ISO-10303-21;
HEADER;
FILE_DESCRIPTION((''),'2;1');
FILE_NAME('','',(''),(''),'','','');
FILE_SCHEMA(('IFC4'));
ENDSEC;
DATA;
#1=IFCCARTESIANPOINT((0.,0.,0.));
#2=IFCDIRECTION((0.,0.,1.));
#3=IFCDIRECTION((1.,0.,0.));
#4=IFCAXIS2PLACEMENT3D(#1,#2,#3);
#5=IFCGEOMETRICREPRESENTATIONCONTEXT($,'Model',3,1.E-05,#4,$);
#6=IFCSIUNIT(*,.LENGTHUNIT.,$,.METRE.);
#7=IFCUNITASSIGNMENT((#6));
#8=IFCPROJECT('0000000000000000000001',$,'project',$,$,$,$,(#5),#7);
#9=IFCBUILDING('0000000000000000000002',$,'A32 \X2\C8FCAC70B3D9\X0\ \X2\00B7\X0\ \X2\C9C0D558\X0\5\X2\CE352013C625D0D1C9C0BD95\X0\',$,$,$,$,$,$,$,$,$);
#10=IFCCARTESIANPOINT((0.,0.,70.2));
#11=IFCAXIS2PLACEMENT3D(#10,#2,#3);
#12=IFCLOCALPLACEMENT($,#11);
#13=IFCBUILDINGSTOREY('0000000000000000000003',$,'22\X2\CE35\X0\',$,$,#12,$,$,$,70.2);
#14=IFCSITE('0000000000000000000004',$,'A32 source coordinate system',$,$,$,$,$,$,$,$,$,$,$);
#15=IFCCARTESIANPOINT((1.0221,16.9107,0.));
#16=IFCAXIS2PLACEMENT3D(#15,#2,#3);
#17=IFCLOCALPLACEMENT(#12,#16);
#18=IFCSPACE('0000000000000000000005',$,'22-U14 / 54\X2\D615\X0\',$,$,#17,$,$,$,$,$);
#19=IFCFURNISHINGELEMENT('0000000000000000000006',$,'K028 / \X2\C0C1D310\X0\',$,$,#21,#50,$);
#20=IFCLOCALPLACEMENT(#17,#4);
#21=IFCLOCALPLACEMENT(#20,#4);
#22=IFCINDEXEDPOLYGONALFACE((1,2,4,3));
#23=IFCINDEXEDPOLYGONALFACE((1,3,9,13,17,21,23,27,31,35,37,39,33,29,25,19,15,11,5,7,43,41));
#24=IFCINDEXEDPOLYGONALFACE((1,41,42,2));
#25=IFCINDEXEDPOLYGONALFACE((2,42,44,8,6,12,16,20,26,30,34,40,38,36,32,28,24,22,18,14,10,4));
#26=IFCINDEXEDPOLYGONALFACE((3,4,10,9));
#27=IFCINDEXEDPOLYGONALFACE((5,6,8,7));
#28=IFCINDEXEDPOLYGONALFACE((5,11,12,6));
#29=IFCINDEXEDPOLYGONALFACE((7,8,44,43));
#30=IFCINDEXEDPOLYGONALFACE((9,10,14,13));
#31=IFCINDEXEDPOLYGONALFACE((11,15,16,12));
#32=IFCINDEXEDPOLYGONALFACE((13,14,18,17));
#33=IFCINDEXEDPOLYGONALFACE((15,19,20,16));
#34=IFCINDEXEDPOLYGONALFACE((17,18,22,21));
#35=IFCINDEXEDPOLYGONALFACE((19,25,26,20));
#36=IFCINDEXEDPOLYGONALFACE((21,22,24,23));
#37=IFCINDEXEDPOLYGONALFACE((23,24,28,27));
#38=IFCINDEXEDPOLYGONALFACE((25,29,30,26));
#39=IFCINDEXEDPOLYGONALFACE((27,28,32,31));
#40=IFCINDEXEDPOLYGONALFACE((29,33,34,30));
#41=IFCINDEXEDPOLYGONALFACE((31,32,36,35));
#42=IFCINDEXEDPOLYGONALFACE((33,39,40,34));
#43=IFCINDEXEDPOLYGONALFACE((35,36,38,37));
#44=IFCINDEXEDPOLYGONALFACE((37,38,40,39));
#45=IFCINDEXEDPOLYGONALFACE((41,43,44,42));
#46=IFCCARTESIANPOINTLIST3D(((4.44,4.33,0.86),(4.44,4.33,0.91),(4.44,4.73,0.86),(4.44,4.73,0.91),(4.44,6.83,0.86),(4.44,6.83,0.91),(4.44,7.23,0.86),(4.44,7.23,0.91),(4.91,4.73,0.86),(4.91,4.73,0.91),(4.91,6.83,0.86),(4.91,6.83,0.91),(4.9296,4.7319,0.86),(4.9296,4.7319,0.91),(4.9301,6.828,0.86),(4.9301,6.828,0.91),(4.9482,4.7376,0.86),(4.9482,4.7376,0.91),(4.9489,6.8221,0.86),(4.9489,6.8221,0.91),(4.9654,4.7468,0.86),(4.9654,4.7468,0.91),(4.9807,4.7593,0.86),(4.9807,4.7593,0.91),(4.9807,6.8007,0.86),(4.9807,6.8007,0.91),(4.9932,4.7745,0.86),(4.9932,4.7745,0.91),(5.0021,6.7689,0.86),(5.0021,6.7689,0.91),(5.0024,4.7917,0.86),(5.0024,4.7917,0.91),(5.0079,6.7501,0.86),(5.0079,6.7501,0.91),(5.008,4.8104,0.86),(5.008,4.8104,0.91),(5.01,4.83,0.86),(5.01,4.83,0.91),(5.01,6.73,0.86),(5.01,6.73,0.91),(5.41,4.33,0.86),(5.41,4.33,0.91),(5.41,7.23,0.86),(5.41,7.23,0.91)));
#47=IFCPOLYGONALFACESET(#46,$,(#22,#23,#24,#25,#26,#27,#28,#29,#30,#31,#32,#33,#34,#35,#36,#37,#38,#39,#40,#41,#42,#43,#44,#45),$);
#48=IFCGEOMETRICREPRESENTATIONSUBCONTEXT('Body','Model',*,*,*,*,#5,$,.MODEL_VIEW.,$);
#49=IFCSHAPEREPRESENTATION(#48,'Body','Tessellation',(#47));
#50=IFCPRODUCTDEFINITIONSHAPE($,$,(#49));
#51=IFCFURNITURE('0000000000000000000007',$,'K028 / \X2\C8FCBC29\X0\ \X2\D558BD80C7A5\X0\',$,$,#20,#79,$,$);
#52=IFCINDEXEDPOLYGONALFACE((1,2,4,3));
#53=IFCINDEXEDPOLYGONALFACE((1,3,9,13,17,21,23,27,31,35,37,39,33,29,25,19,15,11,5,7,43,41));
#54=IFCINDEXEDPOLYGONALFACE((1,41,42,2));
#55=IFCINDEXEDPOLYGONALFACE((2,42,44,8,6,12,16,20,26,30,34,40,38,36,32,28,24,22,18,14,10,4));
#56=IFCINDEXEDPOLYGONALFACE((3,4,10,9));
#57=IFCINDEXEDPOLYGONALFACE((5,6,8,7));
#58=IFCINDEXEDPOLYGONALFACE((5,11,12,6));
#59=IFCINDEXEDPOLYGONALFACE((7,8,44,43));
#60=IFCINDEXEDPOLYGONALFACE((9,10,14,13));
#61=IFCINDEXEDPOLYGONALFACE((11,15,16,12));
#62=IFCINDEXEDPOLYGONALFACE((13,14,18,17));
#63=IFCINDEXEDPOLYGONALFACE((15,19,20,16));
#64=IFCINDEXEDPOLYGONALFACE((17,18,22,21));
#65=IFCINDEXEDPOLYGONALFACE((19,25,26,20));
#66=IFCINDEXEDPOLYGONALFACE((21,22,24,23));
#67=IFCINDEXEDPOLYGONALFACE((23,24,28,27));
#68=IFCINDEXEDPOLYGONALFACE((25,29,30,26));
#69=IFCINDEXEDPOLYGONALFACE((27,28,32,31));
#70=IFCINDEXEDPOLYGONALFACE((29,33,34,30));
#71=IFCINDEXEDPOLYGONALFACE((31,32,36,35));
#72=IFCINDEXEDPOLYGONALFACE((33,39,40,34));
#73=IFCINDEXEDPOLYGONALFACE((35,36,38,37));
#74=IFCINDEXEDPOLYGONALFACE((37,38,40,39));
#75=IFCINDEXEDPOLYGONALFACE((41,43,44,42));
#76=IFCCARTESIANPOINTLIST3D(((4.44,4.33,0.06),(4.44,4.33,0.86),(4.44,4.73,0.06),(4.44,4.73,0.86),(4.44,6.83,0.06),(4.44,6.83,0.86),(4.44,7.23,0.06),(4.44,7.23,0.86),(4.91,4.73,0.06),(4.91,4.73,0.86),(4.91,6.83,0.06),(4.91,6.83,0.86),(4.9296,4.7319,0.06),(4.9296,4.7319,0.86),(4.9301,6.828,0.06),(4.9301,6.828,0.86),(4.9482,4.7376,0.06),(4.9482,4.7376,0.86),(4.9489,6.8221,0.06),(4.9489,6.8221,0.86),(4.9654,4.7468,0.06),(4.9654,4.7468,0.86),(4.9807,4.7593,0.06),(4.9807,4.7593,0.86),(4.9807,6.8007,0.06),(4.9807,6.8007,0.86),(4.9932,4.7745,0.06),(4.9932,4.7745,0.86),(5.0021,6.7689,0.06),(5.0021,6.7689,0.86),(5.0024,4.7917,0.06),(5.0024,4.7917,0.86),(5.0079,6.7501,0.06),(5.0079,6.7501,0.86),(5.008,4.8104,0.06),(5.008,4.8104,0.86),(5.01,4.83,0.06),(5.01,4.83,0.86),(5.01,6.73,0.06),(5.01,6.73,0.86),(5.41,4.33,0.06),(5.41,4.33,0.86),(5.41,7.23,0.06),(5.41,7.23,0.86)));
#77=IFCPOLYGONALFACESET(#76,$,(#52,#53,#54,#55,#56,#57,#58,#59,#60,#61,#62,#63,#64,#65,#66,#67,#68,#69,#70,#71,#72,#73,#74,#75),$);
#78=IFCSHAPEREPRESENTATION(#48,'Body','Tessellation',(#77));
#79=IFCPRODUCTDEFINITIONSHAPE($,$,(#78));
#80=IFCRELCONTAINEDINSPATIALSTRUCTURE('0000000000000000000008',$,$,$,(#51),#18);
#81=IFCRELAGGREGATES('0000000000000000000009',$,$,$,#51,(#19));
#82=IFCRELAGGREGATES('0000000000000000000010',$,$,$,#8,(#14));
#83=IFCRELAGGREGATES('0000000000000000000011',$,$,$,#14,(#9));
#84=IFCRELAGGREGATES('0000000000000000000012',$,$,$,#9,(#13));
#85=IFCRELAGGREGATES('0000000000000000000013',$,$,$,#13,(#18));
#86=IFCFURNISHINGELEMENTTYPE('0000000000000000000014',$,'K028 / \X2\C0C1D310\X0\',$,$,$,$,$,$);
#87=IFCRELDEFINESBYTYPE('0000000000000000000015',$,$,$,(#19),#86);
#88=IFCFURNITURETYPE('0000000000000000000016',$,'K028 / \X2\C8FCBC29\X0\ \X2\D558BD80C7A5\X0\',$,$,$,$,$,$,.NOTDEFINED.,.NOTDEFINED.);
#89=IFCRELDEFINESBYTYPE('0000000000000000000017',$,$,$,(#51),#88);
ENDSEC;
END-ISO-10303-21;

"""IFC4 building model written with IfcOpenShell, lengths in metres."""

from ifc_helpers import new_model, si_unit, frame, origin, origin_with_axes, place, context, subcontext, project, spatial, polyline, outline, extrude, source, transform, mapped, type_object, type_shapes, element, aggregate, save


model = new_model("IFC4")

# Units and contexts
model_context = context("Model", 3, precision=1e-05, world=origin_with_axes())
body_context = subcontext(model_context, "Body", "Model", "MODEL_VIEW")
ifc_project = project(units=[si_unit("LENGTHUNIT", "METRE")], contexts=[model_context])

# Site, building, storey, space
site = spatial("IfcSite", under=ifc_project, Name="A32 source coordinate system")
building = spatial("IfcBuilding", under=site, Name="A32 주거동 · 지하5층–옥탑지붕")
storey_placement = place(None, frame((0.0, 0.0, 70.2), z_axis=(0.0, 0.0, 1.0), x_axis=(1.0, 0.0, 0.0)))
storey = spatial("IfcBuildingStorey", under=building, at=storey_placement, Name="22층", Elevation=70.2)
space_placement = place(storey_placement, frame((1.0221, 16.9107, 0.0), z_axis=(0.0, 0.0, 1.0), x_axis=(1.0, 0.0, 0.0)))
space = spatial("IfcSpace", under=storey, at=space_placement, Name="22-U14 / 54형")

# Furnishing element
furnishing_element_type_1 = type_object("IfcFurnishingElementType", Name="K028 / 상판")
shared_shape_1 = source(origin(), body_context, "Body", "SweptSolid", [
    extrude(outline(polyline([(5.41, 4.33), (4.44, 4.33), (4.44, 4.73), (4.91, 4.73), (4.9296, 4.7319), (4.9482, 4.7376), (4.9654, 4.7468), (4.9807, 4.7593), (4.9932, 4.7745), (5.0024, 4.7917), (5.008, 4.8104), (5.01, 4.83), (5.01, 6.73), (5.0079, 6.7501), (5.0021, 6.7689), (4.9807, 6.8007), (4.9489, 6.8221), (4.9301, 6.828), (4.91, 6.83), (4.44, 6.83), (4.44, 7.23), (5.41, 7.23), (5.41, 4.33)])), frame((0.0, 0.0, 0.86)), (0.0, 0.0, 1.0), 0.05),
])
type_shapes(furnishing_element_type_1, [shared_shape_1])
furniture_1_placement = place(space_placement, origin_with_axes())
furnishing_1_placement = place(furniture_1_placement, origin_with_axes())
furnishing_1 = element("IfcFurnishingElement", 1, at=furnishing_1_placement, type_object=furnishing_element_type_1, Name="K028 / 상판", context=body_context, shape_type="MappedRepresentation", body=[
    mapped(shared_shape_1, transform((0.0, 0.0, 0.0), scale=1.0)),
])

# Furniture
furniture_type_1 = type_object("IfcFurnitureType", Name="K028 / 주방 하부장", AssemblyPlace="NOTDEFINED", PredefinedType="NOTDEFINED")
shared_shape_2 = source(origin(), body_context, "Body", "SweptSolid", [
    extrude(outline(polyline([(5.41, 7.23), (5.41, 4.33), (4.44, 4.33), (4.44, 4.73), (4.91, 4.73), (4.9296, 4.7319), (4.9482, 4.7376), (4.9654, 4.7468), (4.9807, 4.7593), (4.9932, 4.7745), (5.0024, 4.7917), (5.008, 4.8104), (5.01, 4.83), (5.01, 6.73), (5.0079, 6.7501), (5.0021, 6.7689), (4.9807, 6.8007), (4.9489, 6.8221), (4.9301, 6.828), (4.91, 6.83), (4.44, 6.83), (4.44, 7.23), (5.41, 7.23)])), frame((0.0, 0.0, 0.06)), (0.0, 0.0, 1.0), 0.8),
])
type_shapes(furniture_type_1, [shared_shape_2])
furniture_1 = element("IfcFurniture", 2, at=furniture_1_placement, inside=space, type_object=furniture_type_1, Name="K028 / 주방 하부장", context=body_context, shape_type="MappedRepresentation", body=[
    mapped(shared_shape_2, transform((0.0, 0.0, 0.0), scale=1.0)),
])
aggregate(furniture_1, [furnishing_1])

save(model, "model.ifc")
